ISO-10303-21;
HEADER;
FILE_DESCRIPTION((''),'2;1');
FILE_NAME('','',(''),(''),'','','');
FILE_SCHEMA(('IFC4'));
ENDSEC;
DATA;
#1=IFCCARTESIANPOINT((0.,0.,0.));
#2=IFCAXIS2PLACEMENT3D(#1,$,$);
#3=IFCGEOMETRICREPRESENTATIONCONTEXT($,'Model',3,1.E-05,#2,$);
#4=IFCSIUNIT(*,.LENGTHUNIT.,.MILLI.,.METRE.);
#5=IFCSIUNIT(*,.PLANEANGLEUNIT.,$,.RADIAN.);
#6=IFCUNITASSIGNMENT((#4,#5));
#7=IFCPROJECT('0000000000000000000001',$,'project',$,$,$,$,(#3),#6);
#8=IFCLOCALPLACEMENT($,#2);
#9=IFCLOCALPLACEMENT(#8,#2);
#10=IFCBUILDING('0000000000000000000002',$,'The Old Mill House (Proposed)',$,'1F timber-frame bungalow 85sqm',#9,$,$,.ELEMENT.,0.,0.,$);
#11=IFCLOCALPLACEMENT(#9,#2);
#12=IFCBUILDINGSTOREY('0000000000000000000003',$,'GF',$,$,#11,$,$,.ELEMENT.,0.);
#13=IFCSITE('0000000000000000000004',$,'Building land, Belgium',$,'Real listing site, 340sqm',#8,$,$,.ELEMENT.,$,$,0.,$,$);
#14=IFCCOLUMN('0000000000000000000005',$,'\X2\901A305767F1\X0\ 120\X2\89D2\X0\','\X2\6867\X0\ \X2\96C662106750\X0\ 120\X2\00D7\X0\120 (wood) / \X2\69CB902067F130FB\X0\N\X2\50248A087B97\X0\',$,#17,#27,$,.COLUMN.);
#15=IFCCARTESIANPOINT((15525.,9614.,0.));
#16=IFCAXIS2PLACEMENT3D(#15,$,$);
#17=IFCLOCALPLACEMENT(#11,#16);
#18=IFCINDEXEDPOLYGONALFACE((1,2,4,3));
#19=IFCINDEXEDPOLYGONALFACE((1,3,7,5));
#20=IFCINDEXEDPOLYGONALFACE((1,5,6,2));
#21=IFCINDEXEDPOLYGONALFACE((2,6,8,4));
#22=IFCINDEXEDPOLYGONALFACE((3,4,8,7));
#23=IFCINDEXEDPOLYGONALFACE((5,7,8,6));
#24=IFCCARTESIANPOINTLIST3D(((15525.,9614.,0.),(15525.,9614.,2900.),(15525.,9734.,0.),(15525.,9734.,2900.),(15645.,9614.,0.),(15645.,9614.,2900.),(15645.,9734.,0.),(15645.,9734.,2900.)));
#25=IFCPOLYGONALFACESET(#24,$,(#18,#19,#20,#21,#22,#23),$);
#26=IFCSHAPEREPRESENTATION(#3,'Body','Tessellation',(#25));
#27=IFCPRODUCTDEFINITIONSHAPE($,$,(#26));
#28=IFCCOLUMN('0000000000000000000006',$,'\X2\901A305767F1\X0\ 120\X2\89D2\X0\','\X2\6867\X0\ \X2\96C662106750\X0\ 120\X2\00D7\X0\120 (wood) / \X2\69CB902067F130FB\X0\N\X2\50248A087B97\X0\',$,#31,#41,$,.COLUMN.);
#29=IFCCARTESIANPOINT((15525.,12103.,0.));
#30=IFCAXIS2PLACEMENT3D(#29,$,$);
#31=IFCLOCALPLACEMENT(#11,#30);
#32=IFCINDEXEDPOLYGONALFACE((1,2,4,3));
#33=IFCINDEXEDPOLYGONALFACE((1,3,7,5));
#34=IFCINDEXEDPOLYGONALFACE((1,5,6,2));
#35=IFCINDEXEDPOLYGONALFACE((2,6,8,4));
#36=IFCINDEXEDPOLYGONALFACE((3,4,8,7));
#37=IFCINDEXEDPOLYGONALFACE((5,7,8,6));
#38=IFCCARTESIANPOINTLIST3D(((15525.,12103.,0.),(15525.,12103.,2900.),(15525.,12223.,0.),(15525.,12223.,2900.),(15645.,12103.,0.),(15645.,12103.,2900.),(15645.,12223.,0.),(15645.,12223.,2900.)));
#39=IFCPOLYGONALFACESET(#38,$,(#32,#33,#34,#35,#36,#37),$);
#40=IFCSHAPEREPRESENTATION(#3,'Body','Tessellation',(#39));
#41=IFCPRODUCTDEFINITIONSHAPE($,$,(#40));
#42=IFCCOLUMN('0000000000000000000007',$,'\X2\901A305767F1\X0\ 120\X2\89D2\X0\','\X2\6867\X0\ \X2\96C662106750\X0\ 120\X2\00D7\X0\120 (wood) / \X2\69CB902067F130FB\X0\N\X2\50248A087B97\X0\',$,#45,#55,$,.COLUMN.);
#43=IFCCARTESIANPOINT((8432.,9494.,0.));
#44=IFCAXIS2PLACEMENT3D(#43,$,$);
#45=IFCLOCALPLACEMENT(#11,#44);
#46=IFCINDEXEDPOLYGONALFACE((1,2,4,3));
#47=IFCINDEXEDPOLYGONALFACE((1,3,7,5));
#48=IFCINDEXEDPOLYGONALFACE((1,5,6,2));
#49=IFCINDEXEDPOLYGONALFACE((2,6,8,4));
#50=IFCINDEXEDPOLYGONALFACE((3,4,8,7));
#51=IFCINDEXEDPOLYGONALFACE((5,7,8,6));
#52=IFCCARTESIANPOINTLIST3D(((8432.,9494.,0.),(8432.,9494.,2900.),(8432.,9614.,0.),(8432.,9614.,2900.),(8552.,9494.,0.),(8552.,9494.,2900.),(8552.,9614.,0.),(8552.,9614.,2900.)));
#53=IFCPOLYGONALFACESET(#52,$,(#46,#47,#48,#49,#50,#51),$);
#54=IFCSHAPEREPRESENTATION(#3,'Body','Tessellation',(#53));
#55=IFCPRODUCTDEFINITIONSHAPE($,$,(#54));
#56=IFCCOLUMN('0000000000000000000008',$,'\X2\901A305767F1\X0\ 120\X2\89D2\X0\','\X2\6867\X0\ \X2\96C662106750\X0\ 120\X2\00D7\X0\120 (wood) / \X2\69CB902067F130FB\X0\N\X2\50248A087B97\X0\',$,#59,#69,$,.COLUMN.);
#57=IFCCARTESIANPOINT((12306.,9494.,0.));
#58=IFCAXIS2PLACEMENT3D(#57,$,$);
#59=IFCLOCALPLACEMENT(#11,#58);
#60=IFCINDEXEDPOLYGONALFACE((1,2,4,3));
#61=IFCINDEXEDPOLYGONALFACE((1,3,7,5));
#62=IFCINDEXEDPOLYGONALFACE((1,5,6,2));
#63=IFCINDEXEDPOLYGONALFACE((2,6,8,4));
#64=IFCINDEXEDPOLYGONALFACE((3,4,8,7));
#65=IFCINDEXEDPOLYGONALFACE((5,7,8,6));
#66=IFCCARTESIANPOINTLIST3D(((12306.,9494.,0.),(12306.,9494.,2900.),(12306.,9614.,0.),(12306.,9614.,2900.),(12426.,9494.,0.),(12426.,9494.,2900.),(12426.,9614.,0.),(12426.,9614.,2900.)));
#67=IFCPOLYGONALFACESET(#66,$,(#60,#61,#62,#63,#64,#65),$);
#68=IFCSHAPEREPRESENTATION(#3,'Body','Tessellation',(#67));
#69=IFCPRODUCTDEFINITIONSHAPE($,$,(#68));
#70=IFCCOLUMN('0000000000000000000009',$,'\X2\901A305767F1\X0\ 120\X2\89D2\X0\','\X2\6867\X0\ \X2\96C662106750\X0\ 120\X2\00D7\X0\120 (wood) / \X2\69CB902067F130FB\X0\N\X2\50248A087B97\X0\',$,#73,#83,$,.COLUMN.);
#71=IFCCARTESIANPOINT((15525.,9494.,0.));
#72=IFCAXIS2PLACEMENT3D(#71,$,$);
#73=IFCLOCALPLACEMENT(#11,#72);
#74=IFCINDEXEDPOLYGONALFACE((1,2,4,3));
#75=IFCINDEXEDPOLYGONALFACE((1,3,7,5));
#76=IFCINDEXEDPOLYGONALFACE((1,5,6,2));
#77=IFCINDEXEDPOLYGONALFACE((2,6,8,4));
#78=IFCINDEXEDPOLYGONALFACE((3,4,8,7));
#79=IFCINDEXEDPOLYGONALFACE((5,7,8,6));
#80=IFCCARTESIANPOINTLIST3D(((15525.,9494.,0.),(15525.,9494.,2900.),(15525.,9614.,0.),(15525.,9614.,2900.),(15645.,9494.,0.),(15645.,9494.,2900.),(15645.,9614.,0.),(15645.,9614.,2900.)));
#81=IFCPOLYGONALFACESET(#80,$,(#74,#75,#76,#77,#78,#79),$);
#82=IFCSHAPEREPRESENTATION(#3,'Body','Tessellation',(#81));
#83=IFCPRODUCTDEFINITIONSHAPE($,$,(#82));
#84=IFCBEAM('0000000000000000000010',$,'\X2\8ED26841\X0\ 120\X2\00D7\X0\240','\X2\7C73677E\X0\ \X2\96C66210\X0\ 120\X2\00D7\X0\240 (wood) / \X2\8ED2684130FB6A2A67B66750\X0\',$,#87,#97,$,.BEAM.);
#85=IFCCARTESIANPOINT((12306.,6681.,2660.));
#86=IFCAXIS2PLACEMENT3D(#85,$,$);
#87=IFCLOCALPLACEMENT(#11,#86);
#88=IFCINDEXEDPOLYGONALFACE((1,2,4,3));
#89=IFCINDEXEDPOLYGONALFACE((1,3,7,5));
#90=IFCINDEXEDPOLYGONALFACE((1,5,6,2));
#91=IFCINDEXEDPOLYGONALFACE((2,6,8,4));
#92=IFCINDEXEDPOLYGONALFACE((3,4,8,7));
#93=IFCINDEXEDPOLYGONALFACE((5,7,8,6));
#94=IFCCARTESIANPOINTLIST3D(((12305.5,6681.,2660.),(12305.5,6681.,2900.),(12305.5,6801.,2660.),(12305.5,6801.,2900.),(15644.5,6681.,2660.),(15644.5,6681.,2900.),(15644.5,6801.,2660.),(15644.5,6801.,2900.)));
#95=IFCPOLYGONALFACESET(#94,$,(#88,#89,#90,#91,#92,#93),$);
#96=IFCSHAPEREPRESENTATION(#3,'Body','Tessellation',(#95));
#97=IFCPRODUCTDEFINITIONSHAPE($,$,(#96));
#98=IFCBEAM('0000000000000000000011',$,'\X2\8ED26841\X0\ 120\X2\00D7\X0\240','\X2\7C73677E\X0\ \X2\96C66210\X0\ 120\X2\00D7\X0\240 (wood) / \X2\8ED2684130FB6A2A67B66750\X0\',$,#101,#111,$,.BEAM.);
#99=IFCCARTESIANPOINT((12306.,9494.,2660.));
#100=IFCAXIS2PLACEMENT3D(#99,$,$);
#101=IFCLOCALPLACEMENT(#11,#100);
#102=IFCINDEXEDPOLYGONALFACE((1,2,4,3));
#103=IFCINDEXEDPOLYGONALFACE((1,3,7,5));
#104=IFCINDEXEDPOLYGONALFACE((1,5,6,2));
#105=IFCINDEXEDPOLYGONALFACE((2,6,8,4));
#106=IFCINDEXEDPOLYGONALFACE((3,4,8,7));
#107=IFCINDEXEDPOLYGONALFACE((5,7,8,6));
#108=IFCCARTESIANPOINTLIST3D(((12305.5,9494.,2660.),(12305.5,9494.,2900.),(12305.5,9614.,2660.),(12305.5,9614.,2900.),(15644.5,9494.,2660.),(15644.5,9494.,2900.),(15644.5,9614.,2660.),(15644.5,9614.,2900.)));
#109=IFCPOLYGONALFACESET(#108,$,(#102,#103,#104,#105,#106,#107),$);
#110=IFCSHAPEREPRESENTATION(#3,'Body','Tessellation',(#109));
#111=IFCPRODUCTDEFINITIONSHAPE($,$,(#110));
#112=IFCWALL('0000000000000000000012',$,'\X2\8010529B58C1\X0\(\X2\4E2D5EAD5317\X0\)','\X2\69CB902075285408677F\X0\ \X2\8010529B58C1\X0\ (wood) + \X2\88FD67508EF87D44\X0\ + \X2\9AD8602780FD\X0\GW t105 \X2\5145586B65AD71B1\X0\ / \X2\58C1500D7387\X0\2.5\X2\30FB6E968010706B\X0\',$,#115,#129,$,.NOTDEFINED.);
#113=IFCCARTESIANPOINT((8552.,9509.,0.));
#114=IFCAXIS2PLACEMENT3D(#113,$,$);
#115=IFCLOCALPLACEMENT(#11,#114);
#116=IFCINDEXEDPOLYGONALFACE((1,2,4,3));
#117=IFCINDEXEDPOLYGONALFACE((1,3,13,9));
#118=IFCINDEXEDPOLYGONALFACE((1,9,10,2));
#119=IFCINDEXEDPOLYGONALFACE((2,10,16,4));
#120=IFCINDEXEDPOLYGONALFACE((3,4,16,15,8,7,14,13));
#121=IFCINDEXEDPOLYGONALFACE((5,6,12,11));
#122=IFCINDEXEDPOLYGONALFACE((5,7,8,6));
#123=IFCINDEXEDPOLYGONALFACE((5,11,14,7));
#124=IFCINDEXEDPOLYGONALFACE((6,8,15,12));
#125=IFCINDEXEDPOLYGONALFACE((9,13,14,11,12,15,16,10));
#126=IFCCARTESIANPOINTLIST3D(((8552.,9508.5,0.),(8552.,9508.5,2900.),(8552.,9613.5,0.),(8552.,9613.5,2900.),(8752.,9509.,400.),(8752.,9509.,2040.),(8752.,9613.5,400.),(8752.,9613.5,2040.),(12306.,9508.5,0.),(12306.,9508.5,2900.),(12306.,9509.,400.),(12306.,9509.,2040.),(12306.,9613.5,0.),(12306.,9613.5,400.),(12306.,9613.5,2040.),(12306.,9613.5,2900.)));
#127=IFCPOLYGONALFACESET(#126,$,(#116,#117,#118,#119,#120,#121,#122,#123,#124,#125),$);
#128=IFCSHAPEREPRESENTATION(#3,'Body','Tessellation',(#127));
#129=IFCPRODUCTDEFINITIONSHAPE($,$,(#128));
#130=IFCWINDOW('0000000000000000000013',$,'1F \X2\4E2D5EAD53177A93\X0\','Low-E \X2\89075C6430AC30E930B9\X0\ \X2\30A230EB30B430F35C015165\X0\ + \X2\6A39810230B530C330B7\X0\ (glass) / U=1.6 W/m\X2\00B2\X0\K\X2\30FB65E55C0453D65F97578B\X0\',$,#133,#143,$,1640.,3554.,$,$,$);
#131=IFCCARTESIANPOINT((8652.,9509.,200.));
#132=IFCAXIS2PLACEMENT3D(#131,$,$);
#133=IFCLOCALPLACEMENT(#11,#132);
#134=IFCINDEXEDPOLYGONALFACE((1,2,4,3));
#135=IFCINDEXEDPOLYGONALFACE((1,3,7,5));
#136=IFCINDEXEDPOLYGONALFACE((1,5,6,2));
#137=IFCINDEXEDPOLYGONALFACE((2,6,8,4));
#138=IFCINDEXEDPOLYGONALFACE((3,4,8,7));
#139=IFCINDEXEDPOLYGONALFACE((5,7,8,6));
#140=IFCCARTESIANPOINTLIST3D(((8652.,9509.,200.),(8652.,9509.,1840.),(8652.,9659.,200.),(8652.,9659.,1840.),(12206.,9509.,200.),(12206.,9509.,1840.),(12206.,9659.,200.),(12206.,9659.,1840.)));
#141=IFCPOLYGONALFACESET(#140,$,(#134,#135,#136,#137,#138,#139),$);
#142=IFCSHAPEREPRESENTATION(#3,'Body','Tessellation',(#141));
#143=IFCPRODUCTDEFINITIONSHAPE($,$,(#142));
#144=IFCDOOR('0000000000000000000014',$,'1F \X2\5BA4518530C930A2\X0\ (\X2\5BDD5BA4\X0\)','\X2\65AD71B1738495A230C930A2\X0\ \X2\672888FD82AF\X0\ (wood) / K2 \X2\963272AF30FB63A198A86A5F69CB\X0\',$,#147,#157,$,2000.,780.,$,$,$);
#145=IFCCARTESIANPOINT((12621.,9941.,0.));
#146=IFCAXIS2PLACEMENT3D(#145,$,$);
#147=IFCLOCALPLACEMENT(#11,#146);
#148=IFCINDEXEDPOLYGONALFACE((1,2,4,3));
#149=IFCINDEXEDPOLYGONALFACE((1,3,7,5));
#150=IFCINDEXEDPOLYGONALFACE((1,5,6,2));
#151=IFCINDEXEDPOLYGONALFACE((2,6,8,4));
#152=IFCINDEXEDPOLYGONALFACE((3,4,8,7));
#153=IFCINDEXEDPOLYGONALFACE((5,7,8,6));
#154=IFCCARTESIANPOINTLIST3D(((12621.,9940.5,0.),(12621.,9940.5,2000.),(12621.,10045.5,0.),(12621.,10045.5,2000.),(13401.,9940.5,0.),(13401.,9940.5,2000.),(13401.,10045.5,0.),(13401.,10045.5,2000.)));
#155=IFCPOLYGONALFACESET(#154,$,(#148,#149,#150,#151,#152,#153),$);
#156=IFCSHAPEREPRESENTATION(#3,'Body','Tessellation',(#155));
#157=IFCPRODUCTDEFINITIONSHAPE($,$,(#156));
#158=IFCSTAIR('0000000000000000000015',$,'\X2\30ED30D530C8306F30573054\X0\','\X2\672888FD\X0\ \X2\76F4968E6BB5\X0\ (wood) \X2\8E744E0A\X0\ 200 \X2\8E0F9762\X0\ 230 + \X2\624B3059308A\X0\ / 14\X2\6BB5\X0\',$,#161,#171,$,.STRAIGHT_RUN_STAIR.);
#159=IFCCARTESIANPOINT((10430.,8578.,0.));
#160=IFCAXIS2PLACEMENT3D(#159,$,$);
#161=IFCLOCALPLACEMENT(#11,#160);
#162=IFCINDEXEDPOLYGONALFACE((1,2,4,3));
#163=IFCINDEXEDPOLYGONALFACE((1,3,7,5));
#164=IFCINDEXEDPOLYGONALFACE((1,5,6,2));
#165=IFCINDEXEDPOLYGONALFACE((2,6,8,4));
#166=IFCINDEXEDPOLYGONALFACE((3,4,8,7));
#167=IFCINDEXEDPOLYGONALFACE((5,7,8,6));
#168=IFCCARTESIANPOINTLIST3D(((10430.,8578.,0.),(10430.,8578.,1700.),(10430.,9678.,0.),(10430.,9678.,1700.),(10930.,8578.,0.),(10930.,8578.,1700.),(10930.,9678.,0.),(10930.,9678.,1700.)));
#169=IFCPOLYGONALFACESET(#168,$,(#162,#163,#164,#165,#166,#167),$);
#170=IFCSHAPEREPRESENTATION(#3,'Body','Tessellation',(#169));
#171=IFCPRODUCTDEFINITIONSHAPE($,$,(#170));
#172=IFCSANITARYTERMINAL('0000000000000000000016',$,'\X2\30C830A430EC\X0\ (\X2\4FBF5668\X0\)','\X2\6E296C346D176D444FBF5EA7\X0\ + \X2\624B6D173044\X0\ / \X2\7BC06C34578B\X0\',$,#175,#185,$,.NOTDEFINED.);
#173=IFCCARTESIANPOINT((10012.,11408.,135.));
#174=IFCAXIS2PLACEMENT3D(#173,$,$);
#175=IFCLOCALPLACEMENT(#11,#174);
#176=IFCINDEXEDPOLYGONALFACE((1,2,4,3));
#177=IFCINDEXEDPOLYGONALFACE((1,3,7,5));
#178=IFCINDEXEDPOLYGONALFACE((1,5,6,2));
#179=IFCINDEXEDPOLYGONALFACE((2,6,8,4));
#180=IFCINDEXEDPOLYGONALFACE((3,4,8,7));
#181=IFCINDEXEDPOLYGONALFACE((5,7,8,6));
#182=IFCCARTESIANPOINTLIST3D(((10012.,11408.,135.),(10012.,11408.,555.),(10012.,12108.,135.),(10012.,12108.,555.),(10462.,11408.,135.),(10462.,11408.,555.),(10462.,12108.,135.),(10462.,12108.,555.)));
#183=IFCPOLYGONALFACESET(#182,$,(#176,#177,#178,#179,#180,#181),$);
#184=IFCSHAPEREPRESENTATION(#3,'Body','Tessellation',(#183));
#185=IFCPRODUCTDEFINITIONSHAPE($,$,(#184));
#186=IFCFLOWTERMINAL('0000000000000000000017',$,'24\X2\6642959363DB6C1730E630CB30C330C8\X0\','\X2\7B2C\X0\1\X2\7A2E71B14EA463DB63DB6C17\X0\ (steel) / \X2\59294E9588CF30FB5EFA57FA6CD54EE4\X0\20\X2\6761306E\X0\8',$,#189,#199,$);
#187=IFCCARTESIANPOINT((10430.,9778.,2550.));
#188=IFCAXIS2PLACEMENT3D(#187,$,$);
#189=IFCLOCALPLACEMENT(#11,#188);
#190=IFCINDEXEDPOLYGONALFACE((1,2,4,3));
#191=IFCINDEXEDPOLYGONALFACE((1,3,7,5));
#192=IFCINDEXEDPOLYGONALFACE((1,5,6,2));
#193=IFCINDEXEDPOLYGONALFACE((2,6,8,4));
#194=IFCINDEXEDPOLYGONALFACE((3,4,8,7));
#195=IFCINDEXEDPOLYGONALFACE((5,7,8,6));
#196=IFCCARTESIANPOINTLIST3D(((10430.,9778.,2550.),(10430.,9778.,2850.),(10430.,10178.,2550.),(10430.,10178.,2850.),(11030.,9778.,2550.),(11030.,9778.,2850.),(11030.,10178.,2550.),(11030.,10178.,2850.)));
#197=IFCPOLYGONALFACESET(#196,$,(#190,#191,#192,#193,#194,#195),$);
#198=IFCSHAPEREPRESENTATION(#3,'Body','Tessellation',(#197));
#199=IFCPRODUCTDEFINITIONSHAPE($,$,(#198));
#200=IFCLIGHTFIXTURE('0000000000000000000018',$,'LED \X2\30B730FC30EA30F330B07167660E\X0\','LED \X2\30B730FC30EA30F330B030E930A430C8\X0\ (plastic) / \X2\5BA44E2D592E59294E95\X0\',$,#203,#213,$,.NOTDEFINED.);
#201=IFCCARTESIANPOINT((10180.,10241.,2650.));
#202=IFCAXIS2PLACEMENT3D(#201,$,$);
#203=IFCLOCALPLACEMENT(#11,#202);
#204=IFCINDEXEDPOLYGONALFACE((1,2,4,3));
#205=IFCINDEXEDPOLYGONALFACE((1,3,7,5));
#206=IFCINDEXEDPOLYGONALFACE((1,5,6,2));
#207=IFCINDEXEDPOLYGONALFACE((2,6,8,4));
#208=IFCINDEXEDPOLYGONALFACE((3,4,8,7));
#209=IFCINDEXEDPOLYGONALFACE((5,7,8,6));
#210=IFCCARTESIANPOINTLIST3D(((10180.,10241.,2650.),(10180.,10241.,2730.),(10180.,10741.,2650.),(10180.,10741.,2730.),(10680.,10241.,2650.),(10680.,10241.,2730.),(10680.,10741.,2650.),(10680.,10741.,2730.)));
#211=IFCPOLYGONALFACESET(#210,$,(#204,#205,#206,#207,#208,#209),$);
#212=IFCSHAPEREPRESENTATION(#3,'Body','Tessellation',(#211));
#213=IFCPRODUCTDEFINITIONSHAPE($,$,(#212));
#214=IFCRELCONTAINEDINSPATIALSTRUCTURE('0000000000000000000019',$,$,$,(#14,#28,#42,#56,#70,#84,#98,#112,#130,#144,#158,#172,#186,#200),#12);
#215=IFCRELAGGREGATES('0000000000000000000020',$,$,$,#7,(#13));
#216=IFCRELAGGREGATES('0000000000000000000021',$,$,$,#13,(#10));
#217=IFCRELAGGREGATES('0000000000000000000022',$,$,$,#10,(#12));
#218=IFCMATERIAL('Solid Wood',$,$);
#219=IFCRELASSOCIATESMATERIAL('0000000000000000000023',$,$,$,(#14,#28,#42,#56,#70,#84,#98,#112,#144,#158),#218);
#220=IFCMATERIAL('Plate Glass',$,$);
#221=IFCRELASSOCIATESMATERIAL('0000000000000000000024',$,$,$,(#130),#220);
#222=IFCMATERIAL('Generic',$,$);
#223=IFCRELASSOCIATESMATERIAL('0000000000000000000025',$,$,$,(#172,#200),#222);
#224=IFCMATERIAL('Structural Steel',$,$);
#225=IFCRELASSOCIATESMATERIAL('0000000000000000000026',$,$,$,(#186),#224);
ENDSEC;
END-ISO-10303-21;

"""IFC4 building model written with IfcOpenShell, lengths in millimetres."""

from ifc_helpers import new_model, si_unit, frame, frame_2d, origin, place, context, project, spatial, rectangle, extrude, material, element, fill, save


model = new_model("IFC4")

# Units and contexts
model_context = context("Model", 3, precision=1e-05, world=origin())
ifc_project = project(units=[si_unit("LENGTHUNIT", "METRE", prefix="MILLI"), si_unit("PLANEANGLEUNIT", "RADIAN")], contexts=[model_context])

# Site, building, storey
site_placement = place(None, origin())
site = spatial("IfcSite", under=ifc_project, at=site_placement, Name="Building land, Belgium", ObjectType="Real listing site, 340sqm", CompositionType="ELEMENT", RefElevation=0.0)
building_placement = place(site_placement, origin())
building = spatial("IfcBuilding", under=site, at=building_placement, Name="The Old Mill House (Proposed)", ObjectType="1F timber-frame bungalow 85sqm", CompositionType="ELEMENT", ElevationOfRefHeight=0.0, ElevationOfTerrain=0.0)
storey_placement = place(building_placement, origin())
storey = spatial("IfcBuildingStorey", under=building, at=storey_placement, Name="GF", CompositionType="ELEMENT", Elevation=0.0)

# Columns
ifc_material_1 = material(Name="Solid Wood")
column_1_placement = place(storey_placement, frame((15525.0, 9614.0, 0.0)))
element("IfcColumn", 1, at=column_1_placement, inside=storey, material=ifc_material_1, Name="通し柱 120角", Description="桧 集成材 120×120 (wood) / 構造柱・N値計算", PredefinedType="COLUMN", context=model_context, shape_type="SweptSolid", body=[
    extrude(rectangle(XDim=120.0, YDim=120.0, at=frame_2d((60.0, 60.0))), frame((15525.0, 9614.0, 0.0)), (0.0, 0.0, 1.0), 2900.0),
])
column_2_placement = place(storey_placement, frame((15525.0, 12103.0, 0.0)))
element("IfcColumn", 2, at=column_2_placement, inside=storey, material=ifc_material_1, Name="通し柱 120角", Description="桧 集成材 120×120 (wood) / 構造柱・N値計算", PredefinedType="COLUMN", context=model_context, shape_type="SweptSolid", body=[
    extrude(rectangle(XDim=120.0, YDim=120.0, at=frame_2d((60.0, 60.0))), frame((15525.0, 12103.0, 0.0)), (0.0, 0.0, 1.0), 2900.0),
])
column_3_placement = place(storey_placement, frame((8432.0, 9494.0, 0.0)))
element("IfcColumn", 3, at=column_3_placement, inside=storey, material=ifc_material_1, Name="通し柱 120角", Description="桧 集成材 120×120 (wood) / 構造柱・N値計算", PredefinedType="COLUMN", context=model_context, shape_type="SweptSolid", body=[
    extrude(rectangle(XDim=120.0, YDim=120.0, at=frame_2d((60.0, 60.0))), frame((8432.0, 9494.0, 0.0)), (0.0, 0.0, 1.0), 2900.0),
])
column_4_placement = place(storey_placement, frame((12306.0, 9494.0, 0.0)))
element("IfcColumn", 4, at=column_4_placement, inside=storey, material=ifc_material_1, Name="通し柱 120角", Description="桧 集成材 120×120 (wood) / 構造柱・N値計算", PredefinedType="COLUMN", context=model_context, shape_type="SweptSolid", body=[
    extrude(rectangle(XDim=120.0, YDim=120.0, at=frame_2d((60.0, 60.0))), frame((12306.0, 9494.0, 0.0)), (0.0, 0.0, 1.0), 2900.0),
])
column_5_placement = place(storey_placement, frame((15525.0, 9494.0, 0.0)))
element("IfcColumn", 5, at=column_5_placement, inside=storey, material=ifc_material_1, Name="通し柱 120角", Description="桧 集成材 120×120 (wood) / 構造柱・N値計算", PredefinedType="COLUMN", context=model_context, shape_type="SweptSolid", body=[
    extrude(rectangle(XDim=120.0, YDim=120.0, at=frame_2d((60.0, 60.0))), frame((15525.0, 9494.0, 0.0)), (0.0, 0.0, 1.0), 2900.0),
])

# Beams
beam_1_placement = place(storey_placement, frame((12306.0, 6681.0, 2660.0)))
element("IfcBeam", 6, at=beam_1_placement, inside=storey, material=ifc_material_1, Name="軒桁 120×240", Description="米松 集成 120×240 (wood) / 軒桁・横架材", PredefinedType="BEAM", context=model_context, shape_type="SweptSolid", body=[
    extrude(rectangle(XDim=3339.0, YDim=120.0, at=frame_2d((1669.0, 60.0))), frame((12306.0, 6681.0, 2660.0)), (0.0, 0.0, 1.0), 240.0),
])
beam_2_placement = place(storey_placement, frame((12306.0, 9494.0, 2660.0)))
element("IfcBeam", 7, at=beam_2_placement, inside=storey, material=ifc_material_1, Name="軒桁 120×240", Description="米松 集成 120×240 (wood) / 軒桁・横架材", PredefinedType="BEAM", context=model_context, shape_type="SweptSolid", body=[
    extrude(rectangle(XDim=3339.0, YDim=120.0, at=frame_2d((1669.0, 60.0))), frame((12306.0, 9494.0, 2660.0)), (0.0, 0.0, 1.0), 240.0),
])

# Wall, opening, window
wall_1_placement = place(storey_placement, frame((8552.0, 9509.0, 0.0)))
wall_1 = element("IfcWall", 8, at=wall_1_placement, inside=storey, material=ifc_material_1, Name="耐力壁(中庭北)", Description="構造用合板 耐力壁 (wood) + 製材軸組 + 高性能GW t105 充填断熱 / 壁倍率2.5・準耐火", PredefinedType="NOTDEFINED", context=model_context, shape_type="SweptSolid", body=[
    extrude(rectangle(XDim=3754.0, YDim=105.0, at=frame_2d((1877.0, 52.0))), frame((8552.0, 9509.0, 0.0)), (0.0, 0.0, 1.0), 2900.0),
])
opening_placement = place(storey_placement, frame((8652.0, 9509.0, 200.0)))
opening = element("IfcOpeningElement", 9, at=opening_placement, cuts=wall_1, PredefinedType="NOTDEFINED", context=model_context, shape_type="SweptSolid", body=[
    extrude(rectangle(XDim=3554.0, YDim=150.0, at=frame_2d((1777.0, 75.0))), frame((8652.0, 9509.0, 200.0)), (0.0, 0.0, 1.0), 1640.0),
])
ifc_material_2 = material(Name="Plate Glass")
window_placement = place(storey_placement, frame((8652.0, 9509.0, 200.0)))
window = element("IfcWindow", 10, at=window_placement, inside=storey, material=ifc_material_2, Name="1F 中庭北窓", Description="Low-E 複層ガラス アルゴン封入 + 樹脂サッシ (glass) / U=1.6 W/m²K・日射取得型", OverallHeight=1640.0, OverallWidth=3554.0, context=model_context, shape_type="SweptSolid", body=[
    extrude(rectangle(XDim=3554.0, YDim=150.0, at=frame_2d((1777.0, 75.0))), frame((8652.0, 9509.0, 200.0)), (0.0, 0.0, 1.0), 1640.0),
])
fill(opening, window)

# Door
door_placement = place(storey_placement, frame((12621.0, 9941.0, 0.0)))
element("IfcDoor", 11, at=door_placement, inside=storey, material=ifc_material_1, Name="1F 室内ドア (寝室)", Description="断熱玄関ドア 木製芯 (wood) / K2 防犯・採風機構", OverallHeight=2000.0, OverallWidth=780.0, context=model_context, shape_type="SweptSolid", body=[
    extrude(rectangle(XDim=780.0, YDim=105.0, at=frame_2d((390.0, 52.0))), frame((12621.0, 9941.0, 0.0)), (0.0, 0.0, 1.0), 2000.0),
])

# Stair
stair_placement = place(storey_placement, frame((10430.0, 8578.0, 0.0)))
element("IfcStair", 12, at=stair_placement, inside=storey, material=ifc_material_1, Name="ロフトはしご", Description="木製 直階段 (wood) 蹴上 200 踏面 230 + 手すり / 14段", PredefinedType="STRAIGHT_RUN_STAIR", context=model_context, shape_type="SweptSolid", body=[
    extrude(rectangle(XDim=500.0, YDim=1100.0, at=frame_2d((250.0, 550.0))), frame((10430.0, 8578.0, 0.0)), (0.0, 0.0, 1.0), 1700.0),
])

# Shared definitions
ifc_material_3 = material(Name="Generic")

# Sanitary terminal
sanitary_terminal_placement = place(storey_placement, frame((10012.0, 11408.0, 135.0)))
element("IfcSanitaryTerminal", 13, at=sanitary_terminal_placement, inside=storey, material=ifc_material_3, Name="トイレ (便器)", Description="温水洗浄便座 + 手洗い / 節水型", PredefinedType="NOTDEFINED", context=model_context, shape_type="SweptSolid", body=[
    extrude(rectangle(XDim=450.0, YDim=700.0, at=frame_2d((225.0, 350.0))), frame((10012.0, 11408.0, 135.0)), (0.0, 0.0, 1.0), 420.0),
])

# Flow terminal
ifc_material_4 = material(Name="Structural Steel")
flow_terminal_placement = place(storey_placement, frame((10430.0, 9778.0, 2550.0)))
element("IfcFlowTerminal", 14, at=flow_terminal_placement, inside=storey, material=ifc_material_4, Name="24時間換気ユニット", Description="第1種熱交換換気 (steel) / 天井裏・建基法令20条の8", context=model_context, shape_type="SweptSolid", body=[
    extrude(rectangle(XDim=600.0, YDim=400.0, at=frame_2d((300.0, 200.0))), frame((10430.0, 9778.0, 2550.0)), (0.0, 0.0, 1.0), 300.0),
])

# Light fixture
light_fixture_1_placement = place(storey_placement, frame((10180.0, 10241.0, 2650.0)))
element("IfcLightFixture", 15, at=light_fixture_1_placement, inside=storey, material=ifc_material_3, Name="LED シーリング照明", Description="LED シーリングライト (plastic) / 室中央天井", PredefinedType="NOTDEFINED", context=model_context, shape_type="SweptSolid", body=[
    extrude(rectangle(XDim=500.0, YDim=500.0, at=frame_2d((250.0, 250.0))), frame((10180.0, 10241.0, 2650.0)), (0.0, 0.0, 1.0), 80.0),
])

save(model, "model.ifc")
